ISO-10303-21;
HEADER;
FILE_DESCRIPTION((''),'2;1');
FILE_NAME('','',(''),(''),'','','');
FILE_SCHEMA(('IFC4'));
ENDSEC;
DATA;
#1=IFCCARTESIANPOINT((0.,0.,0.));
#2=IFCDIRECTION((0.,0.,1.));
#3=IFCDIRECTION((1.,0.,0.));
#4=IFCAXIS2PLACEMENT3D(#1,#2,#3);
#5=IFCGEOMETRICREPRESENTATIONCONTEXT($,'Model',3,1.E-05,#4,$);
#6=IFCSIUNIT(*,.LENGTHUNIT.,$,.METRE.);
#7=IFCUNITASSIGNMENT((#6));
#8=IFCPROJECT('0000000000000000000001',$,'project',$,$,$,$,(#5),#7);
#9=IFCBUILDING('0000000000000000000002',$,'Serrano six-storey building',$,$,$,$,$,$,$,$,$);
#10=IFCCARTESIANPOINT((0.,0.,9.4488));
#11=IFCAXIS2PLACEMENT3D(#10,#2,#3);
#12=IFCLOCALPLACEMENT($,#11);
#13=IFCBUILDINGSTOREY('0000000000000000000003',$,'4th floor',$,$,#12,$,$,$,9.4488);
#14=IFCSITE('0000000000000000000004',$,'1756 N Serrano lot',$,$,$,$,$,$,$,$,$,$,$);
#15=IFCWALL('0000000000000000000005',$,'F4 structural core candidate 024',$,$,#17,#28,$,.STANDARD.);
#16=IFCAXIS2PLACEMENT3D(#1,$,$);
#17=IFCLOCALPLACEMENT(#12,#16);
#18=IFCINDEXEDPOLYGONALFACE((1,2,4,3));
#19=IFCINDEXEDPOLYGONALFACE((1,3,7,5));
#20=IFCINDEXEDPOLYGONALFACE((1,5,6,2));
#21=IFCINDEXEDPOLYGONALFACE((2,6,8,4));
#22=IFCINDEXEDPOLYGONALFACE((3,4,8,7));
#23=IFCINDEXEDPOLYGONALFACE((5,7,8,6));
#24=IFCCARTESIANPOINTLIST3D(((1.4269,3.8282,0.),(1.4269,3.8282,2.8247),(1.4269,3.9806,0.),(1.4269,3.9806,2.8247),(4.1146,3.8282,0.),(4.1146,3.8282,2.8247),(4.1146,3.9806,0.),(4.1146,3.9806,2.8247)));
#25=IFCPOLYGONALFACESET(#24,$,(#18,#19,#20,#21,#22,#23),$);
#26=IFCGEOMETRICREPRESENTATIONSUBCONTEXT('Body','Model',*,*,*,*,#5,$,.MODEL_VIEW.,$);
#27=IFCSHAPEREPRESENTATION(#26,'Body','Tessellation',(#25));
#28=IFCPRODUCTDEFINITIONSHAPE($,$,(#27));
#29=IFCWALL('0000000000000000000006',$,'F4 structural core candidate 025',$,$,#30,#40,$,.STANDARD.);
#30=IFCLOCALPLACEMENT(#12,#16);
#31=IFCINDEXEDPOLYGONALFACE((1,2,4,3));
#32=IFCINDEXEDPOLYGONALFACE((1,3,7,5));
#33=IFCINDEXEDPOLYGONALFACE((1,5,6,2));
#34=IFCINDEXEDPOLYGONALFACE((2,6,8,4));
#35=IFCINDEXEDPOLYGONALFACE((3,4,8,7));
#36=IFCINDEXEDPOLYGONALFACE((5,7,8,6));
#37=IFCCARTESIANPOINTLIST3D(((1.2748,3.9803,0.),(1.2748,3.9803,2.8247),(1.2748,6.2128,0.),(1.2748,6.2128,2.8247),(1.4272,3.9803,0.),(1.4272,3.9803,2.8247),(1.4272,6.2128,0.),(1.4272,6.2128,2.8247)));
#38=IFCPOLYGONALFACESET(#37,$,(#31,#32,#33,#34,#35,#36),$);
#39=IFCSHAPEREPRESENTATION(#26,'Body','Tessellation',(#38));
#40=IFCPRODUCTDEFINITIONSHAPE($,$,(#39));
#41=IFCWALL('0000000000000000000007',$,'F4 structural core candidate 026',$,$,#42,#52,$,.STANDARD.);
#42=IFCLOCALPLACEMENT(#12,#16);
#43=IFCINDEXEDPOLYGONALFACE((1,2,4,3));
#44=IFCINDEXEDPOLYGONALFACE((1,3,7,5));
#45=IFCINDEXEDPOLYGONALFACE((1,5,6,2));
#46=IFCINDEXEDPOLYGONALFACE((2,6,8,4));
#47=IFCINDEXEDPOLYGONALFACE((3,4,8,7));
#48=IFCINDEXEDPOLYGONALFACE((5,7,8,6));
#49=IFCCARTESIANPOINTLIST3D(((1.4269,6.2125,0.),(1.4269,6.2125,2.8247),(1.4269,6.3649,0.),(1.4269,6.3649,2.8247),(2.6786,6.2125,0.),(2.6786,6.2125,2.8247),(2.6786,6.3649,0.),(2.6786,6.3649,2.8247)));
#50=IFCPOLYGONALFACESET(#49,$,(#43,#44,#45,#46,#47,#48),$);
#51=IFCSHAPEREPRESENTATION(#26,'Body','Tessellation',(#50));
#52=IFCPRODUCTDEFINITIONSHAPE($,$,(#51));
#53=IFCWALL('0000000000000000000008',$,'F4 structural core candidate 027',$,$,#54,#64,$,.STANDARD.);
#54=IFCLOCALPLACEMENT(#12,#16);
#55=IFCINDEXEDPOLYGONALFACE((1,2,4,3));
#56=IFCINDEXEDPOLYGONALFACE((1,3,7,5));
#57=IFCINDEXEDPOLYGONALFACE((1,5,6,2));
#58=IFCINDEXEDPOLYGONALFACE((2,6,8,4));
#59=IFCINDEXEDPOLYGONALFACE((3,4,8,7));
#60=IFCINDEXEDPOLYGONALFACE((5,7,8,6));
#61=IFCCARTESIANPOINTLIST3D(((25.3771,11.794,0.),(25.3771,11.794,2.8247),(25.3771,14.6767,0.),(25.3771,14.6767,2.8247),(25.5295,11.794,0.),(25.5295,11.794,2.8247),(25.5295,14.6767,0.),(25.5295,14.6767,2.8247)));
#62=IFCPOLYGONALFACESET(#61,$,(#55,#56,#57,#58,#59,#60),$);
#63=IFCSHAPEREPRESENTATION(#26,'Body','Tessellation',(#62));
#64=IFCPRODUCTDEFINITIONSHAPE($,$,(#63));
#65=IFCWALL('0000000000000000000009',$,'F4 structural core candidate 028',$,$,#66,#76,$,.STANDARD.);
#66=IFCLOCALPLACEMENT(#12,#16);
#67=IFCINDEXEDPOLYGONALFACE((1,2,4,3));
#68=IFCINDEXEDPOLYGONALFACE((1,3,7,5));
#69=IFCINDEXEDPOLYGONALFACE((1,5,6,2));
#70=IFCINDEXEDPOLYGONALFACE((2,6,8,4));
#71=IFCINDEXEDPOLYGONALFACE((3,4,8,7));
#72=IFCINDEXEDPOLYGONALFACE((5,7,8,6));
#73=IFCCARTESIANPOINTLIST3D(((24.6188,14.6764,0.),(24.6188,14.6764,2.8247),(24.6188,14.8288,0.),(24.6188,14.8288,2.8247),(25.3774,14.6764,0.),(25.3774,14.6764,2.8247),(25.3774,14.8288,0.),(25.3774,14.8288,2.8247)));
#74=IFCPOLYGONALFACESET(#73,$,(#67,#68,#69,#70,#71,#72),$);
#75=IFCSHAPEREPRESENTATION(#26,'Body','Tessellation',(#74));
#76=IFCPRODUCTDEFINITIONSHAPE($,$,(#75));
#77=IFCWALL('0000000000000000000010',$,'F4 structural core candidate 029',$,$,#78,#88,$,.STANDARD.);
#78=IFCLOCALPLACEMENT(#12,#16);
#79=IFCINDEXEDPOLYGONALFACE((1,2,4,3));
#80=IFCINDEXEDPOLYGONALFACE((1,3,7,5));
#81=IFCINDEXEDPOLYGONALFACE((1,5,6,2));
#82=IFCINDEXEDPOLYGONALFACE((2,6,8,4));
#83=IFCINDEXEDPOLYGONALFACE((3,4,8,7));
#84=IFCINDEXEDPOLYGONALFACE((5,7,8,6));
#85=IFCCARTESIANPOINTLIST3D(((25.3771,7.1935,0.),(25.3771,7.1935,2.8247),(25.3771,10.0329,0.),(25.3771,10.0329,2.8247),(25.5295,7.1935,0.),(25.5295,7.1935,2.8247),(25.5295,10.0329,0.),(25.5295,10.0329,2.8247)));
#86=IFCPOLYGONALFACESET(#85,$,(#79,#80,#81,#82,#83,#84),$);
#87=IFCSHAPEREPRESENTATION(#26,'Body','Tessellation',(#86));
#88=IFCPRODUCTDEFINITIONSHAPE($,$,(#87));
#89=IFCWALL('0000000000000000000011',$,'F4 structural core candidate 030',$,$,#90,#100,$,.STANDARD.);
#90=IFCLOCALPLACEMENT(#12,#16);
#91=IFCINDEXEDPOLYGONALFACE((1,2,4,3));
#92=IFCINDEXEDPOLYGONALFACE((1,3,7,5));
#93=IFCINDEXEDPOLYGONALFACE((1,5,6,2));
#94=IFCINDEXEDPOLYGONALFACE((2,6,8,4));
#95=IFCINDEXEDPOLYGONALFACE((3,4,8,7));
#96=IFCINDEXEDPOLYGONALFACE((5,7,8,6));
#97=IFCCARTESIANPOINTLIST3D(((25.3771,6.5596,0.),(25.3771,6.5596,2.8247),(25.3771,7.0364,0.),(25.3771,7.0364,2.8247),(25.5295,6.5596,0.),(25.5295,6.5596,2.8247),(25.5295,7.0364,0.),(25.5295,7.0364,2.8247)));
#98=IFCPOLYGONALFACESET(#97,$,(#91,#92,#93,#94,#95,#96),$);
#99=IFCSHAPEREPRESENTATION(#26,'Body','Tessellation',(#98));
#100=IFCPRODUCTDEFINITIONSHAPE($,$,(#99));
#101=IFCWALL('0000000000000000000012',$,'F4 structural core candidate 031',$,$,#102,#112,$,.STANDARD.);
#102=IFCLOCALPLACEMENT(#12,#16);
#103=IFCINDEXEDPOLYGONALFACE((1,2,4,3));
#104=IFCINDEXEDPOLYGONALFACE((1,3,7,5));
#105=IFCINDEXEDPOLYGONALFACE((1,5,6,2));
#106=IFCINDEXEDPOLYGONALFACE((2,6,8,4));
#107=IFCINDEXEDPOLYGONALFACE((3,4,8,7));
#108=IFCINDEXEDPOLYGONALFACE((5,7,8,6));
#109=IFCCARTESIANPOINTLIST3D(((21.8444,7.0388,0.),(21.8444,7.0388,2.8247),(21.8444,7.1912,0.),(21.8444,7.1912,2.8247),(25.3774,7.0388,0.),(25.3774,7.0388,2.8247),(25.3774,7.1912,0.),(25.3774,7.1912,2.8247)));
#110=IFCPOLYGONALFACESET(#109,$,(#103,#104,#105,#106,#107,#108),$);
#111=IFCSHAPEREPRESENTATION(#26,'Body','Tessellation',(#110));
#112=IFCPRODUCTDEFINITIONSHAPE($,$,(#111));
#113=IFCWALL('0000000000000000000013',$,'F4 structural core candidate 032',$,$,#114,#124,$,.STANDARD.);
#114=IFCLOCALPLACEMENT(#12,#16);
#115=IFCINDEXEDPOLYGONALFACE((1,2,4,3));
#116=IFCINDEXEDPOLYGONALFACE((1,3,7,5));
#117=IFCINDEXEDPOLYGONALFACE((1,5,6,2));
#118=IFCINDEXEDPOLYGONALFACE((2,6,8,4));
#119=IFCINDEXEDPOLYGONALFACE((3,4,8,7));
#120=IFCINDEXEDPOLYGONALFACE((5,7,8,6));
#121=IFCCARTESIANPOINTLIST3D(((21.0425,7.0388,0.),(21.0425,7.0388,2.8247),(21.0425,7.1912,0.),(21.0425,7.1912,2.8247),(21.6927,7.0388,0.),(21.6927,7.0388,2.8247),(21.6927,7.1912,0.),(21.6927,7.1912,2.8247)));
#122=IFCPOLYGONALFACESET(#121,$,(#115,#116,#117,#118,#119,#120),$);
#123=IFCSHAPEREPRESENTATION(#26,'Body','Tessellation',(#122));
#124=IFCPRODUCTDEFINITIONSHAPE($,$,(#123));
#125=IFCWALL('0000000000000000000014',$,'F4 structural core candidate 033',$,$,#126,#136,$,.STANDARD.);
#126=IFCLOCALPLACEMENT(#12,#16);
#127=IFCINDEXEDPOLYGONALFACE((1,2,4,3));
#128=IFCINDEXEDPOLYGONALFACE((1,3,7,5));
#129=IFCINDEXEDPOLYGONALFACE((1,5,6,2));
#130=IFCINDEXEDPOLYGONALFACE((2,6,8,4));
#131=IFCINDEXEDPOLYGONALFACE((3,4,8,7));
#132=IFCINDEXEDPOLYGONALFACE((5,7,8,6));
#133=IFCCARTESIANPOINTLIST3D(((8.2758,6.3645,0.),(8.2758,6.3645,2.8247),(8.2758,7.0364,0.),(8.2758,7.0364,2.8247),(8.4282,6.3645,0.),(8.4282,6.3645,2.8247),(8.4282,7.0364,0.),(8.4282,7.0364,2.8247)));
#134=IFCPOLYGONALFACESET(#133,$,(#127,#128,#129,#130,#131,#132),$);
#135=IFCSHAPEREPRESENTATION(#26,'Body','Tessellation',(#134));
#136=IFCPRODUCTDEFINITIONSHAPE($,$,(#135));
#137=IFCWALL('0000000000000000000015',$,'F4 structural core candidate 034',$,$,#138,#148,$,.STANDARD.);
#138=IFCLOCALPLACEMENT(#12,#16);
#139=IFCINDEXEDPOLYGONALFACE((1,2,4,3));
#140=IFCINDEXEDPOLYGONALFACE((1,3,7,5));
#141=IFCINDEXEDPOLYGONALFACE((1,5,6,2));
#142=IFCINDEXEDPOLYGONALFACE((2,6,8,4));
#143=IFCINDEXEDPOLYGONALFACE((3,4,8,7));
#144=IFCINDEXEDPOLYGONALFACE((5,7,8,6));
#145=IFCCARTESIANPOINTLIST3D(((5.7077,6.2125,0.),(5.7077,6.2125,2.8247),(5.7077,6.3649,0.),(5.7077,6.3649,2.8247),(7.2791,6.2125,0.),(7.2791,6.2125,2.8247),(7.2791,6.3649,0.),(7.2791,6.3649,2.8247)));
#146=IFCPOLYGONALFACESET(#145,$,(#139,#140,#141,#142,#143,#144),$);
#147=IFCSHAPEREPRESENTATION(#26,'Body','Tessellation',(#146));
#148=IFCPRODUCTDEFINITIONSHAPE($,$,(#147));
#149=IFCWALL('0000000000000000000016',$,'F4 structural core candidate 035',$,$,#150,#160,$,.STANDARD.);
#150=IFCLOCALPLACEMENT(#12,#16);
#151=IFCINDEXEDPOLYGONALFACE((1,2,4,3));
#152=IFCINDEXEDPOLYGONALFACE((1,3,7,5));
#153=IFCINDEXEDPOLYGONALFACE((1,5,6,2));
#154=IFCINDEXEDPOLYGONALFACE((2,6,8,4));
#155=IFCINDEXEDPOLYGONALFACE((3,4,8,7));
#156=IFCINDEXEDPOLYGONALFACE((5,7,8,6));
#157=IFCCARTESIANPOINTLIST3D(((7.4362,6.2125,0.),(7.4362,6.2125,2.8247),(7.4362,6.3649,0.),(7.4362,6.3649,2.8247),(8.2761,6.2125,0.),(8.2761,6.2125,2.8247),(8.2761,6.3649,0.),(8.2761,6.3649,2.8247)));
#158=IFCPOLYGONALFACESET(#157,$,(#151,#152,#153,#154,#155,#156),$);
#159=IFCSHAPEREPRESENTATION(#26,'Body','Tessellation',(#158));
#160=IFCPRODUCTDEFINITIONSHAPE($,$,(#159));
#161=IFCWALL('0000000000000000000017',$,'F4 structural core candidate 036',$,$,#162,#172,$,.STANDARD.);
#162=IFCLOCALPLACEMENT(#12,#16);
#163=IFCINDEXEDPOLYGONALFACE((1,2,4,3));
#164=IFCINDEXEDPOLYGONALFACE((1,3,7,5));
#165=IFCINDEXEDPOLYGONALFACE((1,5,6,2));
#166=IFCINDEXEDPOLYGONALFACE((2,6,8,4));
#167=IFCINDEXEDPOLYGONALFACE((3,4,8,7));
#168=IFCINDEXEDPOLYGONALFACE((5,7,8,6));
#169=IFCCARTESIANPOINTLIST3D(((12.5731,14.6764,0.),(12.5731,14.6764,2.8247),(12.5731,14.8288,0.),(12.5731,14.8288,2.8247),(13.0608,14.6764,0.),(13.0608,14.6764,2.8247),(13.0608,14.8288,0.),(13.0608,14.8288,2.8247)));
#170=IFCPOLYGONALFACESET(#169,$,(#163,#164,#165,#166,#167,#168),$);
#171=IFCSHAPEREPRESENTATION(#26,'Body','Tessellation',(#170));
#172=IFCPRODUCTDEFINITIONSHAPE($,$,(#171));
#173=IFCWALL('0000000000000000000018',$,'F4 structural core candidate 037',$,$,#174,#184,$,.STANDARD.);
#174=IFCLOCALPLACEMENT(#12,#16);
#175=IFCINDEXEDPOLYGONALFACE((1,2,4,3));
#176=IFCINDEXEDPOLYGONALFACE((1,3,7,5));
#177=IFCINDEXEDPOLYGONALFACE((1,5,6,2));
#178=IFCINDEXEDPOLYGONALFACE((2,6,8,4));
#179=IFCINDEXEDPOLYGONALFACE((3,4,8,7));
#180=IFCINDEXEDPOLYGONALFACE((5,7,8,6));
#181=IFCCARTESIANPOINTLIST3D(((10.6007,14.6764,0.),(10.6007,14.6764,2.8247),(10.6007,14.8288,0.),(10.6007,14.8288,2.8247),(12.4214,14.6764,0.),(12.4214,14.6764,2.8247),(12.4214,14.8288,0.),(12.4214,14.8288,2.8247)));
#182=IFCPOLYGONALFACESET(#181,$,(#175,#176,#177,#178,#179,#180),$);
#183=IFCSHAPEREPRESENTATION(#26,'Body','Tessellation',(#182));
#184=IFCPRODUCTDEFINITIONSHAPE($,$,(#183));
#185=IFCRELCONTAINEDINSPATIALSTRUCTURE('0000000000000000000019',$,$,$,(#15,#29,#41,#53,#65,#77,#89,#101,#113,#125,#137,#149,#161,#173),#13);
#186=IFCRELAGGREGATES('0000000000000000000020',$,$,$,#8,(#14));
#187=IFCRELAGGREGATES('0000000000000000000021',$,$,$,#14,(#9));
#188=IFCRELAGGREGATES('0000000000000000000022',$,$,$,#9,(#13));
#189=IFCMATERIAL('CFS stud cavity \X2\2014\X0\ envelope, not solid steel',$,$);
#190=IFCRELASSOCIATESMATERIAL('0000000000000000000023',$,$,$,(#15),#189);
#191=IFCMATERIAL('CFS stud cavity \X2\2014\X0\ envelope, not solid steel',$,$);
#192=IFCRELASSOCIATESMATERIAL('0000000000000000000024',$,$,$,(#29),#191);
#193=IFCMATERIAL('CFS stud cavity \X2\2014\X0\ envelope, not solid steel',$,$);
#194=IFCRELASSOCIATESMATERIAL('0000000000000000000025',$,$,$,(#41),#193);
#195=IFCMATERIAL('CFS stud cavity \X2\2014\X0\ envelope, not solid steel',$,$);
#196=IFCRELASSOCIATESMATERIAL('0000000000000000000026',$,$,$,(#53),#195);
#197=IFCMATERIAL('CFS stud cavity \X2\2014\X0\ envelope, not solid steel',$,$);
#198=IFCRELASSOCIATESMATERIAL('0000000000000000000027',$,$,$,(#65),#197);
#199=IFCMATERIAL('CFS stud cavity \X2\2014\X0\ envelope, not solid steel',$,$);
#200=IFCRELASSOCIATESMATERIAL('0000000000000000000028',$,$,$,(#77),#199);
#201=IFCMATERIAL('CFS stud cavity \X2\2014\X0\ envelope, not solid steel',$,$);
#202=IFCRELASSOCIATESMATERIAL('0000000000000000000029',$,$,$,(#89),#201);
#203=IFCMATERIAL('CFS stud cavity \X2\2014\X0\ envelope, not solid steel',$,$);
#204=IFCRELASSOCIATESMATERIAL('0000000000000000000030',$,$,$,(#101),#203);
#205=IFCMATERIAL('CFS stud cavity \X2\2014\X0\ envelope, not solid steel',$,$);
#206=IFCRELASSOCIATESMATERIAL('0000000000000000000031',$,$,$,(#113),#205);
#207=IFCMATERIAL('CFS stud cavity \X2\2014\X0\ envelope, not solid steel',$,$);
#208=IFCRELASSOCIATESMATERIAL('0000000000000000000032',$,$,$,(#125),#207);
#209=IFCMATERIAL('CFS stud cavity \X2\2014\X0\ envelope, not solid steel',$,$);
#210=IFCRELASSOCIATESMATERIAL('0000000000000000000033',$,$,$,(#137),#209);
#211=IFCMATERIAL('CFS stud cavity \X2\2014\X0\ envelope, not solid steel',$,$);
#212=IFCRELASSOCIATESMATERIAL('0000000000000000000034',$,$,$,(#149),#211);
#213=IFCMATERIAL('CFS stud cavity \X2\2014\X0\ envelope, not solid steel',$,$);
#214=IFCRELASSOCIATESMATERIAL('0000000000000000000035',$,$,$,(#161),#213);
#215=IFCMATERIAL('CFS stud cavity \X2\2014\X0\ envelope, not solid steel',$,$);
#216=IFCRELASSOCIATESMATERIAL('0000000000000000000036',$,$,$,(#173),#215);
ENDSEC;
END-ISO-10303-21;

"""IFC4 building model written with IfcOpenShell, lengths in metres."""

from ifc_helpers import new_model, si_unit, frame, origin_with_axes, place, context, subcontext, project, spatial, polyline, outline, extrude, material, element, save


model = new_model("IFC4")

# Units and contexts
model_context = context("Model", 3, precision=1e-05, world=origin_with_axes())
body_context = subcontext(model_context, "Body", "Model", "MODEL_VIEW")
ifc_project = project(units=[si_unit("LENGTHUNIT", "METRE")], contexts=[model_context])

# Site, building, storey
site = spatial("IfcSite", under=ifc_project, Name="1756 N Serrano lot")
building = spatial("IfcBuilding", under=site, Name="Serrano six-storey building")
storey_placement = place(None, frame((0.0, 0.0, 9.4488), z_axis=(0.0, 0.0, 1.0), x_axis=(1.0, 0.0, 0.0)))
storey = spatial("IfcBuildingStorey", under=building, at=storey_placement, Name="4th floor", Elevation=9.4488)

# Walls
ifc_material_1 = material(Name="CFS stud cavity — envelope, not solid steel")
wall_1_placement = place(storey_placement, frame((0.0, 0.0, -9.4488), z_axis=(0.0, 0.0, 1.0), x_axis=(1.0, 0.0, 0.0)))
element("IfcWall", 1, at=wall_1_placement, inside=storey, material=ifc_material_1, Name="F4 structural core candidate 024", PredefinedType="STANDARD", context=body_context, shape_type="SweptSolid", body=[
    extrude(outline(polyline([(4.1146, 3.9806), (4.1146, 3.8282), (1.4269, 3.8282), (1.4269, 3.9806), (4.1146, 3.9806)])), frame((0.0, 0.0, 9.4488)), (0.0, 0.0, 1.0), 2.8247),
])
ifc_material_2 = material(Name="CFS stud cavity — envelope, not solid steel")
wall_2_placement = place(storey_placement, frame((0.0, 0.0, -9.4488), z_axis=(0.0, 0.0, 1.0), x_axis=(1.0, 0.0, 0.0)))
element("IfcWall", 2, at=wall_2_placement, inside=storey, material=ifc_material_2, Name="F4 structural core candidate 025", PredefinedType="STANDARD", context=body_context, shape_type="SweptSolid", body=[
    extrude(outline(polyline([(1.4272, 3.9803), (1.2748, 3.9803), (1.2748, 6.2128), (1.4272, 6.2128), (1.4272, 3.9803)])), frame((0.0, 0.0, 9.4488)), (0.0, 0.0, 1.0), 2.8247),
])
ifc_material_3 = material(Name="CFS stud cavity — envelope, not solid steel")
wall_3_placement = place(storey_placement, frame((0.0, 0.0, -9.4488), z_axis=(0.0, 0.0, 1.0), x_axis=(1.0, 0.0, 0.0)))
element("IfcWall", 3, at=wall_3_placement, inside=storey, material=ifc_material_3, Name="F4 structural core candidate 026", PredefinedType="STANDARD", context=body_context, shape_type="SweptSolid", body=[
    extrude(outline(polyline([(2.6786, 6.3649), (2.6786, 6.2125), (1.4269, 6.2125), (1.4269, 6.3649), (2.6786, 6.3649)])), frame((0.0, 0.0, 9.4488)), (0.0, 0.0, 1.0), 2.8247),
])
ifc_material_4 = material(Name="CFS stud cavity — envelope, not solid steel")
wall_4_placement = place(storey_placement, frame((0.0, 0.0, -9.4488), z_axis=(0.0, 0.0, 1.0), x_axis=(1.0, 0.0, 0.0)))
element("IfcWall", 4, at=wall_4_placement, inside=storey, material=ifc_material_4, Name="F4 structural core candidate 027", PredefinedType="STANDARD", context=body_context, shape_type="SweptSolid", body=[
    extrude(outline(polyline([(25.5295, 11.794), (25.3771, 11.794), (25.3771, 14.6767), (25.5295, 14.6767), (25.5295, 11.794)])), frame((0.0, 0.0, 9.4488)), (0.0, 0.0, 1.0), 2.8247),
])
ifc_material_5 = material(Name="CFS stud cavity — envelope, not solid steel")
wall_5_placement = place(storey_placement, frame((0.0, 0.0, -9.4488), z_axis=(0.0, 0.0, 1.0), x_axis=(1.0, 0.0, 0.0)))
element("IfcWall", 5, at=wall_5_placement, inside=storey, material=ifc_material_5, Name="F4 structural core candidate 028", PredefinedType="STANDARD", context=body_context, shape_type="SweptSolid", body=[
    extrude(outline(polyline([(25.3774, 14.8288), (25.3774, 14.6764), (24.6188, 14.6764), (24.6188, 14.8288), (25.3774, 14.8288)])), frame((0.0, 0.0, 9.4488)), (0.0, 0.0, 1.0), 2.8247),
])
ifc_material_6 = material(Name="CFS stud cavity — envelope, not solid steel")
wall_6_placement = place(storey_placement, frame((0.0, 0.0, -9.4488), z_axis=(0.0, 0.0, 1.0), x_axis=(1.0, 0.0, 0.0)))
element("IfcWall", 6, at=wall_6_placement, inside=storey, material=ifc_material_6, Name="F4 structural core candidate 029", PredefinedType="STANDARD", context=body_context, shape_type="SweptSolid", body=[
    extrude(outline(polyline([(25.5295, 7.1935), (25.3771, 7.1935), (25.3771, 10.0329), (25.5295, 10.0329), (25.5295, 7.1935)])), frame((0.0, 0.0, 9.4488)), (0.0, 0.0, 1.0), 2.8247),
])
ifc_material_7 = material(Name="CFS stud cavity — envelope, not solid steel")
wall_7_placement = place(storey_placement, frame((0.0, 0.0, -9.4488), z_axis=(0.0, 0.0, 1.0), x_axis=(1.0, 0.0, 0.0)))
element("IfcWall", 7, at=wall_7_placement, inside=storey, material=ifc_material_7, Name="F4 structural core candidate 030", PredefinedType="STANDARD", context=body_context, shape_type="SweptSolid", body=[
    extrude(outline(polyline([(25.5295, 6.5596), (25.3771, 6.5596), (25.3771, 7.0364), (25.5295, 7.0364), (25.5295, 6.5596)])), frame((0.0, 0.0, 9.4488)), (0.0, 0.0, 1.0), 2.8247),
])
ifc_material_8 = material(Name="CFS stud cavity — envelope, not solid steel")
wall_8_placement = place(storey_placement, frame((0.0, 0.0, -9.4488), z_axis=(0.0, 0.0, 1.0), x_axis=(1.0, 0.0, 0.0)))
element("IfcWall", 8, at=wall_8_placement, inside=storey, material=ifc_material_8, Name="F4 structural core candidate 031", PredefinedType="STANDARD", context=body_context, shape_type="SweptSolid", body=[
    extrude(outline(polyline([(25.3774, 7.1912), (25.3774, 7.0388), (21.8444, 7.0388), (21.8444, 7.1912), (25.3774, 7.1912)])), frame((0.0, 0.0, 9.4488)), (0.0, 0.0, 1.0), 2.8247),
])
ifc_material_9 = material(Name="CFS stud cavity — envelope, not solid steel")
wall_9_placement = place(storey_placement, frame((0.0, 0.0, -9.4488), z_axis=(0.0, 0.0, 1.0), x_axis=(1.0, 0.0, 0.0)))
element("IfcWall", 9, at=wall_9_placement, inside=storey, material=ifc_material_9, Name="F4 structural core candidate 032", PredefinedType="STANDARD", context=body_context, shape_type="SweptSolid", body=[
    extrude(outline(polyline([(21.6927, 7.1912), (21.6927, 7.0388), (21.0425, 7.0388), (21.0425, 7.1912), (21.6927, 7.1912)])), frame((0.0, 0.0, 9.4488)), (0.0, 0.0, 1.0), 2.8247),
])
ifc_material_10 = material(Name="CFS stud cavity — envelope, not solid steel")
wall_10_placement = place(storey_placement, frame((0.0, 0.0, -9.4488), z_axis=(0.0, 0.0, 1.0), x_axis=(1.0, 0.0, 0.0)))
element("IfcWall", 10, at=wall_10_placement, inside=storey, material=ifc_material_10, Name="F4 structural core candidate 033", PredefinedType="STANDARD", context=body_context, shape_type="SweptSolid", body=[
    extrude(outline(polyline([(8.4282, 6.3645), (8.2758, 6.3645), (8.2758, 7.0364), (8.4282, 7.0364), (8.4282, 6.3645)])), frame((0.0, 0.0, 9.4488)), (0.0, 0.0, 1.0), 2.8247),
])
ifc_material_11 = material(Name="CFS stud cavity — envelope, not solid steel")
wall_11_placement = place(storey_placement, frame((0.0, 0.0, -9.4488), z_axis=(0.0, 0.0, 1.0), x_axis=(1.0, 0.0, 0.0)))
element("IfcWall", 11, at=wall_11_placement, inside=storey, material=ifc_material_11, Name="F4 structural core candidate 034", PredefinedType="STANDARD", context=body_context, shape_type="SweptSolid", body=[
    extrude(outline(polyline([(7.2791, 6.3649), (7.2791, 6.2125), (5.7077, 6.2125), (5.7077, 6.3649), (7.2791, 6.3649)])), frame((0.0, 0.0, 9.4488)), (0.0, 0.0, 1.0), 2.8247),
])
ifc_material_12 = material(Name="CFS stud cavity — envelope, not solid steel")
wall_12_placement = place(storey_placement, frame((0.0, 0.0, -9.4488), z_axis=(0.0, 0.0, 1.0), x_axis=(1.0, 0.0, 0.0)))
element("IfcWall", 12, at=wall_12_placement, inside=storey, material=ifc_material_12, Name="F4 structural core candidate 035", PredefinedType="STANDARD", context=body_context, shape_type="SweptSolid", body=[
    extrude(outline(polyline([(8.2761, 6.3649), (8.2761, 6.2125), (7.4362, 6.2125), (7.4362, 6.3649), (8.2761, 6.3649)])), frame((0.0, 0.0, 9.4488)), (0.0, 0.0, 1.0), 2.8247),
])
ifc_material_13 = material(Name="CFS stud cavity — envelope, not solid steel")
wall_13_placement = place(storey_placement, frame((0.0, 0.0, -9.4488), z_axis=(0.0, 0.0, 1.0), x_axis=(1.0, 0.0, 0.0)))
element("IfcWall", 13, at=wall_13_placement, inside=storey, material=ifc_material_13, Name="F4 structural core candidate 036", PredefinedType="STANDARD", context=body_context, shape_type="SweptSolid", body=[
    extrude(outline(polyline([(13.0608, 14.8288), (13.0608, 14.6764), (12.5731, 14.6764), (12.5731, 14.8288), (13.0608, 14.8288)])), frame((0.0, 0.0, 9.4488)), (0.0, 0.0, 1.0), 2.8247),
])
ifc_material_14 = material(Name="CFS stud cavity — envelope, not solid steel")
wall_14_placement = place(storey_placement, frame((0.0, 0.0, -9.4488), z_axis=(0.0, 0.0, 1.0), x_axis=(1.0, 0.0, 0.0)))
element("IfcWall", 14, at=wall_14_placement, inside=storey, material=ifc_material_14, Name="F4 structural core candidate 037", PredefinedType="STANDARD", context=body_context, shape_type="SweptSolid", body=[
    extrude(outline(polyline([(12.4214, 14.8288), (12.4214, 14.6764), (10.6007, 14.6764), (10.6007, 14.8288), (12.4214, 14.8288)])), frame((0.0, 0.0, 9.4488)), (0.0, 0.0, 1.0), 2.8247),
])

save(model, "model.ifc")
